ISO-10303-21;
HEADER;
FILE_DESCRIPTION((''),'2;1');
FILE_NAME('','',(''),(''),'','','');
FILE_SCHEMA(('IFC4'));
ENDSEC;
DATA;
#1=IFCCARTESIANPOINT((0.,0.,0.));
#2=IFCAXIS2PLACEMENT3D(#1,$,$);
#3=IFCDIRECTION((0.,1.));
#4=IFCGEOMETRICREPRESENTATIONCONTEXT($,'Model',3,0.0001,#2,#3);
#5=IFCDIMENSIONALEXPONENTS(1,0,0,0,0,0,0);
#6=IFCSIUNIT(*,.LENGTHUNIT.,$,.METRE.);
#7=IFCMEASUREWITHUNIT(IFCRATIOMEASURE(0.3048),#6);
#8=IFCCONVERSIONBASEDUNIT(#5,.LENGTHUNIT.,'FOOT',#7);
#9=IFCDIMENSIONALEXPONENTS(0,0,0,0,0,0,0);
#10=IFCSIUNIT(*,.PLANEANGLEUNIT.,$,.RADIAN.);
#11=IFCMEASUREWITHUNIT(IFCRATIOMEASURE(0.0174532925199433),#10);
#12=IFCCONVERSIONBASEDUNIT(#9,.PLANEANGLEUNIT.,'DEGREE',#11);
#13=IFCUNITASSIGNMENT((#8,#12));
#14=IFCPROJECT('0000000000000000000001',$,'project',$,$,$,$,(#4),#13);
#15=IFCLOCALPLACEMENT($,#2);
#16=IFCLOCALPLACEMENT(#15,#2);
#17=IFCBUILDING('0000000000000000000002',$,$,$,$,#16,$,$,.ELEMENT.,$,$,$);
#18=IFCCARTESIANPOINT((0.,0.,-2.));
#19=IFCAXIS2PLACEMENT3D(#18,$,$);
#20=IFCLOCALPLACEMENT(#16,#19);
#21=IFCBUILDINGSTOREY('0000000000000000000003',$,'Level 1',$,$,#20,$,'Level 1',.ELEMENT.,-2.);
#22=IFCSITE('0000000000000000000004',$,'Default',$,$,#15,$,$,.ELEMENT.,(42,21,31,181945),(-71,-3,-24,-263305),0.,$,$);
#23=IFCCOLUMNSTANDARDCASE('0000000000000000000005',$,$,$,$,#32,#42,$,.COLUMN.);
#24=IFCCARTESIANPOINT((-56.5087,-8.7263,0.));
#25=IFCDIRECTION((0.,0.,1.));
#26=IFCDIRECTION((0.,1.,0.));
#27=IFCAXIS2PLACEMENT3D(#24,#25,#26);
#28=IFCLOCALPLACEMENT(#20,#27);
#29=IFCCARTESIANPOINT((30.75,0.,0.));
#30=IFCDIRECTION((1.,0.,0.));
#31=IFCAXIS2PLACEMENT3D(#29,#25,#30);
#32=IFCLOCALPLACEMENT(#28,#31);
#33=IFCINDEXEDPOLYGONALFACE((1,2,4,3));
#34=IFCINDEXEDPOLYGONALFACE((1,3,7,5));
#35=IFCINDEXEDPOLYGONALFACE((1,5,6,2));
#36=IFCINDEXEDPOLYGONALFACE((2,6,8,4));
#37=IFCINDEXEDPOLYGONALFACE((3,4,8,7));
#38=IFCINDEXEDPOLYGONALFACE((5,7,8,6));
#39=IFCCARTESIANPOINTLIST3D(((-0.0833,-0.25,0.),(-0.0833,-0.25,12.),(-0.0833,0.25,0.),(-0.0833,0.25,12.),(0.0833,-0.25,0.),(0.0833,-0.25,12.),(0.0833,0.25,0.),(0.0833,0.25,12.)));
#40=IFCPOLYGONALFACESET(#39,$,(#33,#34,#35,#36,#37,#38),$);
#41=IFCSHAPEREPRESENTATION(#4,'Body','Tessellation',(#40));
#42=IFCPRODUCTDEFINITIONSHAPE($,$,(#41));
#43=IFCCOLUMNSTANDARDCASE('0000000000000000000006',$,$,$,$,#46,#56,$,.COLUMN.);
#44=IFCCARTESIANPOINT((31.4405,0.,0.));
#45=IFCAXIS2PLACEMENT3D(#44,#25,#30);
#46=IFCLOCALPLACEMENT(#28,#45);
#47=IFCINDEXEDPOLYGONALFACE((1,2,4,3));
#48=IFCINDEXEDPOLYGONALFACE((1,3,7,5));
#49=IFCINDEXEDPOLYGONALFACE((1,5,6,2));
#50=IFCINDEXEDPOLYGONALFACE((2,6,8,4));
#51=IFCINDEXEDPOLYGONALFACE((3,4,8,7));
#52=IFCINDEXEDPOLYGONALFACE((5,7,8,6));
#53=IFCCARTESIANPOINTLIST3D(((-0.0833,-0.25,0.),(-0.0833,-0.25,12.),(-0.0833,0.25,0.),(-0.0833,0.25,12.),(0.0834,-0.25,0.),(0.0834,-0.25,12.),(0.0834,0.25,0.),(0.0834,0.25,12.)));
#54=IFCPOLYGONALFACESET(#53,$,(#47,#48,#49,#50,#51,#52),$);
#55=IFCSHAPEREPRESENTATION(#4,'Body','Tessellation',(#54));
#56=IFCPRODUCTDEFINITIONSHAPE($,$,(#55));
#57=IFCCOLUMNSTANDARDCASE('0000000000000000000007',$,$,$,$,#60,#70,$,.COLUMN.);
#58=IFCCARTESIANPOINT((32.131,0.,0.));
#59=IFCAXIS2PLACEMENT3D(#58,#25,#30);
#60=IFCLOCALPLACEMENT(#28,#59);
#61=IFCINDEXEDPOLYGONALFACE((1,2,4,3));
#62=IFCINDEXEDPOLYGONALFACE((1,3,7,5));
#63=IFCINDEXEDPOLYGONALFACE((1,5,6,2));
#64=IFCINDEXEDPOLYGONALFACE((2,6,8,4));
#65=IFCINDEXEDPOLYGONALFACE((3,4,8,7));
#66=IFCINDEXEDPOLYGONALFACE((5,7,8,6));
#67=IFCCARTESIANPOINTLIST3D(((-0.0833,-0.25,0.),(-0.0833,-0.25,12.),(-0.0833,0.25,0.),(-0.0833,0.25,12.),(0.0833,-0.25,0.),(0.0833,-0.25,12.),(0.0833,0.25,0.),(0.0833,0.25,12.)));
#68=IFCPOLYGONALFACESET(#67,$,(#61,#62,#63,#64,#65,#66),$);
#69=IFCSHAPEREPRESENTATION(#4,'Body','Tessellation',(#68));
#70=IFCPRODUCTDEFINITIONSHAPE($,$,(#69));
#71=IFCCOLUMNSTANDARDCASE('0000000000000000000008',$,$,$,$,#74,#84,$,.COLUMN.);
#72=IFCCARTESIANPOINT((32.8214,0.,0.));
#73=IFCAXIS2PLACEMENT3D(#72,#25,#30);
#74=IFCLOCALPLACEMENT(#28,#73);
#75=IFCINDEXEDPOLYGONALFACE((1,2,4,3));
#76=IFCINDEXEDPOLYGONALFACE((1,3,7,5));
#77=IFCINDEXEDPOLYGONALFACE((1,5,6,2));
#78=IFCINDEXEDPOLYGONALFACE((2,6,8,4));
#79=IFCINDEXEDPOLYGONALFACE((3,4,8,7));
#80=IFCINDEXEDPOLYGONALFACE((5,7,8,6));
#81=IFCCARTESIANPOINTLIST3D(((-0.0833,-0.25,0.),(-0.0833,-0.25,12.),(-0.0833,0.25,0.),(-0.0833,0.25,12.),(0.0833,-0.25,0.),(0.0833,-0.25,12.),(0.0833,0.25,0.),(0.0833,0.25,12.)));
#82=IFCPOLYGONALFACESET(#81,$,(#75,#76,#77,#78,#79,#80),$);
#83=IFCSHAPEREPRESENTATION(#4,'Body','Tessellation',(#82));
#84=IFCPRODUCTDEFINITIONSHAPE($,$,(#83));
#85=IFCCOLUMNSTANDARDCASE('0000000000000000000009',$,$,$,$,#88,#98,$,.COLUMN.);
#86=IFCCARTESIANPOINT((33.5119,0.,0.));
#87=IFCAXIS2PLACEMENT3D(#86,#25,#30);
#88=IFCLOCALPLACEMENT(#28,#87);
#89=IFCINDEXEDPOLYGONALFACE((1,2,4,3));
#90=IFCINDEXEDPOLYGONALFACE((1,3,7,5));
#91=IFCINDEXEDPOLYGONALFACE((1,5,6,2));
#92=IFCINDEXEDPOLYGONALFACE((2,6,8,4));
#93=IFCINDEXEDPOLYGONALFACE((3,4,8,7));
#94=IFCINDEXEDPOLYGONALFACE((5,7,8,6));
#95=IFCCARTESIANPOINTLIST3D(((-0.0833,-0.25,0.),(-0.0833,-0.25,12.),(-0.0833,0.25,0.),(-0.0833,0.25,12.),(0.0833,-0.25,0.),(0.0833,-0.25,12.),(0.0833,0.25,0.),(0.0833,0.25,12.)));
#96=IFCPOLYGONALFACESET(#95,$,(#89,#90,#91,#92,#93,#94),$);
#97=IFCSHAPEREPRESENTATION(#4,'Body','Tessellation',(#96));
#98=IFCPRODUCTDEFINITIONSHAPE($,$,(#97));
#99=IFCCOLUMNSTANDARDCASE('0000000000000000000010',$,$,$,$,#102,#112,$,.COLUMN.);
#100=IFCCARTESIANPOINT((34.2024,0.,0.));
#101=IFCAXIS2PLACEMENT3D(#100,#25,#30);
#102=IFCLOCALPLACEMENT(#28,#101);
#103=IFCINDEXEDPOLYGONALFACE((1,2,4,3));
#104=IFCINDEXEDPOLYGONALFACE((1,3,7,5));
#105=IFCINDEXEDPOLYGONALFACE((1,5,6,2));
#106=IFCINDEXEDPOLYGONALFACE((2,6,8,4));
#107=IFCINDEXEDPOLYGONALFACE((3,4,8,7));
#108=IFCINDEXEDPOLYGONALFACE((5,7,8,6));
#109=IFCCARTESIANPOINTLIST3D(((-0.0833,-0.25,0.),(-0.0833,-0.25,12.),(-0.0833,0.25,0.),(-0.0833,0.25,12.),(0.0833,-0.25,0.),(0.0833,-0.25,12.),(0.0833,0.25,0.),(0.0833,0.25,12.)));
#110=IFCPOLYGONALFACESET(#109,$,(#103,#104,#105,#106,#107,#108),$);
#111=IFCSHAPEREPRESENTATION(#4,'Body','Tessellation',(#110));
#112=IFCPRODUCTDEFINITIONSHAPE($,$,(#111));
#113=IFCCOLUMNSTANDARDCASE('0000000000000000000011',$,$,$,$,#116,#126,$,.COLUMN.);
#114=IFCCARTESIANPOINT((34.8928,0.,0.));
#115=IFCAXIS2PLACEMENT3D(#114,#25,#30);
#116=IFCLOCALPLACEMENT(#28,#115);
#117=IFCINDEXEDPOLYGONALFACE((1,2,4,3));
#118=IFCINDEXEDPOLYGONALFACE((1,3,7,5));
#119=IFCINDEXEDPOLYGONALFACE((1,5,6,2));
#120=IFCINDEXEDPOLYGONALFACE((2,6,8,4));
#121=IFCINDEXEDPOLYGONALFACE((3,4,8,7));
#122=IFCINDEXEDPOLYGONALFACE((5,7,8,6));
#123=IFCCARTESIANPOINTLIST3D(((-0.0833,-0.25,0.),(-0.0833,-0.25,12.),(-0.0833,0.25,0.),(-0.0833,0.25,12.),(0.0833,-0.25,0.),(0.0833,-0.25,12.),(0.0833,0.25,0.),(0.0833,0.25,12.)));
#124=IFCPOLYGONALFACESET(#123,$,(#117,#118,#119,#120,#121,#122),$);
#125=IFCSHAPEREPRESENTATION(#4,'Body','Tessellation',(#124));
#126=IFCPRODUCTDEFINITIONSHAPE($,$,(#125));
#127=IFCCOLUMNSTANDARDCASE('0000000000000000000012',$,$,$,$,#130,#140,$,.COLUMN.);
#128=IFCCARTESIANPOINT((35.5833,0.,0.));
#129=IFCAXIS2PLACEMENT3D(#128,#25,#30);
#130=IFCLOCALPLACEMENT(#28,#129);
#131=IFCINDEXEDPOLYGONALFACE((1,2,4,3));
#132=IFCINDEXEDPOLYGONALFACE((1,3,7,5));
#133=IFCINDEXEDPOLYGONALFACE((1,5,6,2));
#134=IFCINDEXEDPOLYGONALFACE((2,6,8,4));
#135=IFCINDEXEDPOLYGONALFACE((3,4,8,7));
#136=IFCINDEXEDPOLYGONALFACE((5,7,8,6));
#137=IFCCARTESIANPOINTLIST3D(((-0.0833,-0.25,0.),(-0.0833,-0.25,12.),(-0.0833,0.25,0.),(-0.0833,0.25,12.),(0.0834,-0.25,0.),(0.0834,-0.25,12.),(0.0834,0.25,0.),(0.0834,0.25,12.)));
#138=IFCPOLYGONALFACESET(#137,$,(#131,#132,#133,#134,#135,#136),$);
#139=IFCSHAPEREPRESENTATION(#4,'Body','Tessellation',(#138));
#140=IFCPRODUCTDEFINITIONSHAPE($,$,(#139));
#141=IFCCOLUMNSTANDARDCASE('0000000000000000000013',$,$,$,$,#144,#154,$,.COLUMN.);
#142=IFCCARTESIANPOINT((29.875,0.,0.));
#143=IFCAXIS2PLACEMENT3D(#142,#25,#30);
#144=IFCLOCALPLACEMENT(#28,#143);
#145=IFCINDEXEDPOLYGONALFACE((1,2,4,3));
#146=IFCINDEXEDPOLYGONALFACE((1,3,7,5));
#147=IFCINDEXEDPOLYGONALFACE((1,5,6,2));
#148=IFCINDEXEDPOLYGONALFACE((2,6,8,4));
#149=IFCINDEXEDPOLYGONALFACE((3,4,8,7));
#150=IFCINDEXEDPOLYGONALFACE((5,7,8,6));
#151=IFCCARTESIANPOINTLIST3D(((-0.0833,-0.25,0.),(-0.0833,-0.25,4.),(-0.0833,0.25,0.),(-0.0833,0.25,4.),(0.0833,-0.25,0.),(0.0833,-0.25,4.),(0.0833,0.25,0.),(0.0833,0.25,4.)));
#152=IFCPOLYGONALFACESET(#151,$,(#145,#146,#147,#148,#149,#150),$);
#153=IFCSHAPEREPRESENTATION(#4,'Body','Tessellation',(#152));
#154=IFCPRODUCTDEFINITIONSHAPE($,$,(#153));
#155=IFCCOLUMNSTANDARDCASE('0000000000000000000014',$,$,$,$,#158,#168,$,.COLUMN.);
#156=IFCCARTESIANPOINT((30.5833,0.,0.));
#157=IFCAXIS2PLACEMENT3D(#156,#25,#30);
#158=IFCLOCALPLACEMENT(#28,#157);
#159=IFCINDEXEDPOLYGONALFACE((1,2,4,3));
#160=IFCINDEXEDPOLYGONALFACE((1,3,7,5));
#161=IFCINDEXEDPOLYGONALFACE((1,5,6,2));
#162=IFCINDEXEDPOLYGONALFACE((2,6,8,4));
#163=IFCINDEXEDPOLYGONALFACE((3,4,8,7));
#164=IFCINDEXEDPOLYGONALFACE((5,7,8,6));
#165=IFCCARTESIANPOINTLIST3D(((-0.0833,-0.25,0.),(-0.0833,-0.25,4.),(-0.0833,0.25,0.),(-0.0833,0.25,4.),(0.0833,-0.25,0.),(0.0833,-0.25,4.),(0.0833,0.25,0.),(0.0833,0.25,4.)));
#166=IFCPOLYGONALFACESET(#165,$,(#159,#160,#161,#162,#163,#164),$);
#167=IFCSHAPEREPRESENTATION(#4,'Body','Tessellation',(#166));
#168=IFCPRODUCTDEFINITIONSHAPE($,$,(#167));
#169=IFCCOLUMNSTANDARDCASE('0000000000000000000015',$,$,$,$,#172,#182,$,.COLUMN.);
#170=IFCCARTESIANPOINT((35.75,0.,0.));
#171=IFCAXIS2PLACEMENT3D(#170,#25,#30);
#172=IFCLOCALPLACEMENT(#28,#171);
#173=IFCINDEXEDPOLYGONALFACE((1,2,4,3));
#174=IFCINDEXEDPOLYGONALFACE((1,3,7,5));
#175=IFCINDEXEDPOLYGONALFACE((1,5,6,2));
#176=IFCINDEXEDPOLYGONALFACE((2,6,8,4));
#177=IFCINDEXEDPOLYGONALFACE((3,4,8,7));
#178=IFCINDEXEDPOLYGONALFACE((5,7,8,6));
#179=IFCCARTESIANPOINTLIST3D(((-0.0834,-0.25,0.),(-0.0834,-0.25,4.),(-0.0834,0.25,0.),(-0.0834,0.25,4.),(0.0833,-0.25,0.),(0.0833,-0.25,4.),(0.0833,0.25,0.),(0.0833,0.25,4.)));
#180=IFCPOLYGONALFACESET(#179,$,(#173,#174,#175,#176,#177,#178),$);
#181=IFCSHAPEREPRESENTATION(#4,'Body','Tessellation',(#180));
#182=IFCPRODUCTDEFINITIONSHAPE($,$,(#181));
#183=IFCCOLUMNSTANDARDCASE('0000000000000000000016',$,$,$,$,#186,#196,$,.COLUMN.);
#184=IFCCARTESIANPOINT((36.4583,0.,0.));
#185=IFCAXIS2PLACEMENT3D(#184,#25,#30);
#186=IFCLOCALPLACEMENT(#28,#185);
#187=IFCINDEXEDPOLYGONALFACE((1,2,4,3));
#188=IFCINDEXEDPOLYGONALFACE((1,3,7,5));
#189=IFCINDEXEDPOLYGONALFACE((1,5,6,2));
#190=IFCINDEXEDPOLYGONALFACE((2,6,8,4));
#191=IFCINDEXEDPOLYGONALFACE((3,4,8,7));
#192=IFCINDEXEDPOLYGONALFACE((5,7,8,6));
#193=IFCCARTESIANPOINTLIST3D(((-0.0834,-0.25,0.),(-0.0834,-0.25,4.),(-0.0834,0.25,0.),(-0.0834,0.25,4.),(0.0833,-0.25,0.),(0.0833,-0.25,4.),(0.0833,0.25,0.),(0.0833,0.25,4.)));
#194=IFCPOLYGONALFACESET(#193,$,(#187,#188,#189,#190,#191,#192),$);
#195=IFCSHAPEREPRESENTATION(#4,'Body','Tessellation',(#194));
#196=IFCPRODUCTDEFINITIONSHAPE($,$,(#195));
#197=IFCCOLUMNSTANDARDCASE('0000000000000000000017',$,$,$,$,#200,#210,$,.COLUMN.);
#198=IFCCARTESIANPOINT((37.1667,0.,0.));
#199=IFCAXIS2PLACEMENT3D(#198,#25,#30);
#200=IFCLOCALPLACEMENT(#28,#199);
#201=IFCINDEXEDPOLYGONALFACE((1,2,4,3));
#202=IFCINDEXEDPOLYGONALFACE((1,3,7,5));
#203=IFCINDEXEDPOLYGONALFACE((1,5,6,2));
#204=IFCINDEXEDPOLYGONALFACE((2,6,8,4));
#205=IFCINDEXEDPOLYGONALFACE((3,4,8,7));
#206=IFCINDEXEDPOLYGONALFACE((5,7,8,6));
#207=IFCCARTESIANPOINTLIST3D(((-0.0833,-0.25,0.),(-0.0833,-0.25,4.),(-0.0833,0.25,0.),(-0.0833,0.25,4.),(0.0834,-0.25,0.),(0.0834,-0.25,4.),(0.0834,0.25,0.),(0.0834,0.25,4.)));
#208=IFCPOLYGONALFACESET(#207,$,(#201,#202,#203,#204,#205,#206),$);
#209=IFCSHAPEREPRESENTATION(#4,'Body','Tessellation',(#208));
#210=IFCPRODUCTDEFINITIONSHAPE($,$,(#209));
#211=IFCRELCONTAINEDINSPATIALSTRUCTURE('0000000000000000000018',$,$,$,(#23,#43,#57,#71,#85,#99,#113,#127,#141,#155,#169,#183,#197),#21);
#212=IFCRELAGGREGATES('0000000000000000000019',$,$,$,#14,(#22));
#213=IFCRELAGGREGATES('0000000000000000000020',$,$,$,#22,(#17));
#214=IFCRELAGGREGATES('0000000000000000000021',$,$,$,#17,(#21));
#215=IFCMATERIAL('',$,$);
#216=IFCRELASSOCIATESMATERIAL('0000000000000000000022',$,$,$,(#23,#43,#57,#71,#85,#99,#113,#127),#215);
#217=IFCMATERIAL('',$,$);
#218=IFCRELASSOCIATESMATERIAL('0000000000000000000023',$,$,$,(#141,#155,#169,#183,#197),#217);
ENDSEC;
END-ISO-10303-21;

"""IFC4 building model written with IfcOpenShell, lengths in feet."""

from ifc_helpers import new_model, entity, si_unit, converted_unit, direction, frame, origin, place, context, project, spatial, rectangle, extrude, material, element, save


model = new_model("IFC4")

# Units and contexts
model_context = context("Model", 3, precision=0.0001, world=origin(), true_north=direction((0.0, 1.0)))
ifc_project = project(units=[converted_unit("LENGTHUNIT", "FOOT", entity("IfcRatioMeasure", 0.3048), si_unit("LENGTHUNIT", "METRE"), dimensions=[1, 0, 0, 0, 0, 0, 0]), converted_unit("PLANEANGLEUNIT", "DEGREE", entity("IfcRatioMeasure", 0.0174532925199433), si_unit("PLANEANGLEUNIT", "RADIAN"), dimensions=[0, 0, 0, 0, 0, 0, 0])], contexts=[model_context])

# Site, building, storey
site_placement = place(None, origin())
site = spatial("IfcSite", under=ifc_project, at=site_placement, Name="Default", CompositionType="ELEMENT", RefLatitude=(42, 21, 31, 181945), RefLongitude=(-71, -3, -24, -263305), RefElevation=0.0)
building_placement = place(site_placement, origin())
building = spatial("IfcBuilding", under=site, at=building_placement, CompositionType="ELEMENT")
storey_placement = place(building_placement, frame((0.0, 0.0, -2.0)))
storey = spatial("IfcBuildingStorey", under=building, at=storey_placement, Name="Level 1", LongName="Level 1", CompositionType="ELEMENT", Elevation=-2.0)

# Columns
ifc_material_1 = material(Name="")
placement = place(storey_placement, frame((-56.5087, -8.7263, 0.0), z_axis=(0.0, 0.0, 1.0), x_axis=(0.0, 1.0, 0.0)))
for number, where, z_axis, x_axis in (
    (1, (30.75, 0.0, 0.0), (0.0, 0.0, 1.0), (1.0, 0.0, 0.0)),
    (2, (31.4405, 0.0, 0.0), (0.0, 0.0, 1.0), (1.0, 0.0, 0.0)),
    (3, (32.131, 0.0, 0.0), (0.0, 0.0, 1.0), (1.0, 0.0, 0.0)),
    (4, (32.8214, 0.0, 0.0), (0.0, 0.0, 1.0), (1.0, 0.0, 0.0)),
    (5, (33.5119, 0.0, 0.0), (0.0, 0.0, 1.0), (1.0, 0.0, 0.0)),
    (6, (34.2024, 0.0, 0.0), (0.0, 0.0, 1.0), (1.0, 0.0, 0.0)),
    (7, (34.8928, 0.0, 0.0), (0.0, 0.0, 1.0), (1.0, 0.0, 0.0)),
    (8, (35.5833, 0.0, 0.0), (0.0, 0.0, 1.0), (1.0, 0.0, 0.0)),
):
    element("IfcColumnStandardCase", number, at=place(placement, frame(where, z_axis=z_axis, x_axis=x_axis)), inside=storey, material=ifc_material_1, PredefinedType="COLUMN", context=model_context, shape_type="SweptSolid", body=[
        extrude(rectangle(XDim=0.1667, YDim=0.5), origin(), (0.0, 0.0, 1.0), 12.0),
    ])
ifc_material_2 = material(Name="")
for number, where, z_axis, x_axis in (
    (9, (29.875, 0.0, 0.0), (0.0, 0.0, 1.0), (1.0, 0.0, 0.0)),
    (10, (30.5833, 0.0, 0.0), (0.0, 0.0, 1.0), (1.0, 0.0, 0.0)),
    (11, (35.75, 0.0, 0.0), (0.0, 0.0, 1.0), (1.0, 0.0, 0.0)),
    (12, (36.4583, 0.0, 0.0), (0.0, 0.0, 1.0), (1.0, 0.0, 0.0)),
    (13, (37.1667, 0.0, 0.0), (0.0, 0.0, 1.0), (1.0, 0.0, 0.0)),
):
    element("IfcColumnStandardCase", number, at=place(placement, frame(where, z_axis=z_axis, x_axis=x_axis)), inside=storey, material=ifc_material_2, PredefinedType="COLUMN", context=model_context, shape_type="SweptSolid", body=[
        extrude(rectangle(XDim=0.1667, YDim=0.5), origin(), (0.0, 0.0, 1.0), 4.0),
    ])

save(model, "model.ifc")
